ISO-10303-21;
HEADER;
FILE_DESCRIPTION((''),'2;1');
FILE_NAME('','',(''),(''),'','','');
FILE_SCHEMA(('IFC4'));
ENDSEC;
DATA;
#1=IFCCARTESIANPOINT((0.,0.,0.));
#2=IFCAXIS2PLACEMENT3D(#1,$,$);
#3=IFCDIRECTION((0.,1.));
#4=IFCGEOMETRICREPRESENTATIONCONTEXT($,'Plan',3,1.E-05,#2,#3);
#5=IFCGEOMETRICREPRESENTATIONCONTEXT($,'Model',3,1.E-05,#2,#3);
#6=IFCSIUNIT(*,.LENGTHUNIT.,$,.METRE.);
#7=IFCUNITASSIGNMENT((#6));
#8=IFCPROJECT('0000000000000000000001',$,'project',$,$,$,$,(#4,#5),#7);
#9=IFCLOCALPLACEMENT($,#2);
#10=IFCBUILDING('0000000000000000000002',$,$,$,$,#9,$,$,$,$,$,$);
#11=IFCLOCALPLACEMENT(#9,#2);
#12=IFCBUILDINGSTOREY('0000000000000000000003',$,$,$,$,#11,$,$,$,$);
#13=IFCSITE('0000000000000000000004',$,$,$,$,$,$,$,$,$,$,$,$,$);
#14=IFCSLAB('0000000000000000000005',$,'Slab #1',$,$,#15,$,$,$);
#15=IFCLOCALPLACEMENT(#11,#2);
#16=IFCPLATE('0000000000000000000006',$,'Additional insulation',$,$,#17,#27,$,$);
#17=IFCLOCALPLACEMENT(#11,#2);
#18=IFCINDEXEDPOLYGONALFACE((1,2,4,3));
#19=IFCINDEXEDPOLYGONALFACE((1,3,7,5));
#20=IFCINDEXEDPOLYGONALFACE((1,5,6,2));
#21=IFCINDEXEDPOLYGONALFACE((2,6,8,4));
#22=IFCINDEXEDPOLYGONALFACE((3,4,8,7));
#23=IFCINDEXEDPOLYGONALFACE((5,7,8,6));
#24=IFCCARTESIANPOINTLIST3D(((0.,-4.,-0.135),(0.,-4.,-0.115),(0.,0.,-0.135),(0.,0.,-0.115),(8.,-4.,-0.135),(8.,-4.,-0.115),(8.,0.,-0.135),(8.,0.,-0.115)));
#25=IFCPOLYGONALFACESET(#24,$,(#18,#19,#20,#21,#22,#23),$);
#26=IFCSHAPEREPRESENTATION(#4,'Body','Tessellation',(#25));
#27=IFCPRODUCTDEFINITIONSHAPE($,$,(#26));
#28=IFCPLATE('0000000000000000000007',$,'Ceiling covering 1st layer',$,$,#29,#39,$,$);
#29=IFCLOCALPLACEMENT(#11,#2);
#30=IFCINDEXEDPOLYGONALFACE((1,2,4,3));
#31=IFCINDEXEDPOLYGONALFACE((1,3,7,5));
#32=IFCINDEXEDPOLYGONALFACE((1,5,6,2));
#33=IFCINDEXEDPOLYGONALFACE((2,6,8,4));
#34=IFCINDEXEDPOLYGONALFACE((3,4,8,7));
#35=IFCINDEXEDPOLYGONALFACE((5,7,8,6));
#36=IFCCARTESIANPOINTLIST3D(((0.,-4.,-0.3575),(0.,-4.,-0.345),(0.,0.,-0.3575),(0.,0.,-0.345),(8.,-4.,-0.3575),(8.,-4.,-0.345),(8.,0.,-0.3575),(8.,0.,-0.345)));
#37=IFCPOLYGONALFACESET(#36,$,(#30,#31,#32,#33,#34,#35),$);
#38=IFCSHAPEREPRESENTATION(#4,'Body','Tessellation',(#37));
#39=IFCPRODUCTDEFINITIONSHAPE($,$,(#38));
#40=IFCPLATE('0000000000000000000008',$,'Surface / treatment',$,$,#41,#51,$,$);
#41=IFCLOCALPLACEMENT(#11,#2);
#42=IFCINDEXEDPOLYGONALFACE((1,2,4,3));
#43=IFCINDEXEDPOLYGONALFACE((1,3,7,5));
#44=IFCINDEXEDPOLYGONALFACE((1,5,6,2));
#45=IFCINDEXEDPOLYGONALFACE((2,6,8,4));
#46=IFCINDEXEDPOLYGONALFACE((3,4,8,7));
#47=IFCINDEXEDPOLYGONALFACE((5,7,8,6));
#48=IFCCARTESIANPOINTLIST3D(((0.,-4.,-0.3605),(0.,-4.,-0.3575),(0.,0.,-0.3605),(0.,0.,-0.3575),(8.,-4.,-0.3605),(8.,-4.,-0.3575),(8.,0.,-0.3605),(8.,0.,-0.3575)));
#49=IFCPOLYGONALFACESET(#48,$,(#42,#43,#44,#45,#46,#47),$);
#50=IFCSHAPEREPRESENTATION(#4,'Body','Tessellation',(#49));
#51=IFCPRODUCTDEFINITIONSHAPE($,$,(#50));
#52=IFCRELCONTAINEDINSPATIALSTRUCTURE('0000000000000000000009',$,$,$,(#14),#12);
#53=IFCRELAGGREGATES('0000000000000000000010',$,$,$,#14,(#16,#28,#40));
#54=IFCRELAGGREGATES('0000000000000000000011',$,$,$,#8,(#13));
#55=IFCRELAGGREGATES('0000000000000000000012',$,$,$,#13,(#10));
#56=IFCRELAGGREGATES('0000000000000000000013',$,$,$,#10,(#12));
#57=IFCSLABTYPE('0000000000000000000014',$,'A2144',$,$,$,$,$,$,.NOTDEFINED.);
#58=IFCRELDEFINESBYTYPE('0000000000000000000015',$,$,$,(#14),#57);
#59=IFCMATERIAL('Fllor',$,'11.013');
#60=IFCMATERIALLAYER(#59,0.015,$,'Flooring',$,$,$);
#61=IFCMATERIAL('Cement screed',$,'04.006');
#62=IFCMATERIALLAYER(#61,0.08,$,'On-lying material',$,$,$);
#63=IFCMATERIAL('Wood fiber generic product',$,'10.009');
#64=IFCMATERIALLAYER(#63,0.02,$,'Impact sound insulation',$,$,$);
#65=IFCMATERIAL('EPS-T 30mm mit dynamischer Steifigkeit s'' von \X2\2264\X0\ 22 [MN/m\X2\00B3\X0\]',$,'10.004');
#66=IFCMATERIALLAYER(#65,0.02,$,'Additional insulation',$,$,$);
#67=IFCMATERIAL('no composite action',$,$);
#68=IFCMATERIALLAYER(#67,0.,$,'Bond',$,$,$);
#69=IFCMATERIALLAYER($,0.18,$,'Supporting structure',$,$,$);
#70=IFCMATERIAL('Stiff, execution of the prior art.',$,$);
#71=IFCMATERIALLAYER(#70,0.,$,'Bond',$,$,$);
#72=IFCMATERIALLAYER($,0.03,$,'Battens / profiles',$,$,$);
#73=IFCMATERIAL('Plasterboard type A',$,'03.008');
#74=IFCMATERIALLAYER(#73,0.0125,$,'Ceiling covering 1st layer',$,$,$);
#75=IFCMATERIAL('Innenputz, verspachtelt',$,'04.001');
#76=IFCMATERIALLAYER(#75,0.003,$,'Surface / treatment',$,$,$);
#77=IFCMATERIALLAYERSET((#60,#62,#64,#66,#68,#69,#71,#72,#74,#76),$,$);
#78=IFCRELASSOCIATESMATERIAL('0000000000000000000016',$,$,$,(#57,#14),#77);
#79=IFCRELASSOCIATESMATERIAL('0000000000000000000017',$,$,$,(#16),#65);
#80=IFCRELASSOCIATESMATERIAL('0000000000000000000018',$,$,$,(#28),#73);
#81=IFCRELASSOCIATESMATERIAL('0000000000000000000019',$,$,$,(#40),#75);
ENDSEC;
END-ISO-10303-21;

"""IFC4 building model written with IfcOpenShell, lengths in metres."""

from ifc_helpers import new_model, si_unit, direction, frame, frame_2d, origin, place, context, project, spatial, rectangle, extrude, material, layer, layer_set, type_object, element, aggregate, save


model = new_model("IFC4")

# Units and contexts
plan_context = context("Plan", 3, precision=1e-05, world=origin(), true_north=direction((0.0, 1.0)))
model_context = context("Model", 3, precision=1e-05, world=origin(), true_north=direction((0.0, 1.0)))
ifc_project = project(units=[si_unit("LENGTHUNIT", "METRE")], contexts=[plan_context, model_context])

# Site, building, storey
site = spatial("IfcSite", under=ifc_project)
building_placement = place(None, origin())
building = spatial("IfcBuilding", under=site, at=building_placement)
storey_placement = place(building_placement, origin())
storey = spatial("IfcBuildingStorey", under=building, at=storey_placement)

# Slab, plates
ifc_material_1 = material(Name="Fllor", Category="11.013")
ifc_layer_1 = layer(ifc_material_1, 0.015, Name="Flooring")
ifc_material_2 = material(Name="Cement screed", Category="04.006")
ifc_layer_2 = layer(ifc_material_2, 0.08, Name="On-lying material")
ifc_material_3 = material(Name="Wood fiber generic product", Category="10.009")
ifc_layer_3 = layer(ifc_material_3, 0.02, Name="Impact sound insulation")
ifc_material_4 = material(Name="EPS-T 30mm mit dynamischer Steifigkeit s' von ≤ 22 [MN/m³]", Category="10.004")
ifc_layer_4 = layer(ifc_material_4, 0.02, Name="Additional insulation")
ifc_material_5 = material(Name="no composite action")
ifc_layer_5 = layer(ifc_material_5, 0.0, Name="Bond")
ifc_layer_6 = layer(None, 0.18, Name="Supporting structure")
ifc_material_6 = material(Name="Stiff, execution of the prior art.")
ifc_layer_7 = layer(ifc_material_6, 0.0, Name="Bond")
ifc_layer_8 = layer(None, 0.03, Name="Battens / profiles")
ifc_material_7 = material(Name="Plasterboard type A", Category="03.008")
ifc_layer_9 = layer(ifc_material_7, 0.0125, Name="Ceiling covering 1st layer")
ifc_material_8 = material(Name="Innenputz, verspachtelt", Category="04.001")
ifc_layer_10 = layer(ifc_material_8, 0.003, Name="Surface / treatment")
ifc_layer_set = layer_set([ifc_layer_1, ifc_layer_2, ifc_layer_3, ifc_layer_4, ifc_layer_5, ifc_layer_6, ifc_layer_7, ifc_layer_8, ifc_layer_9, ifc_layer_10])
slab_type = type_object("IfcSlabType", Name="A2144", PredefinedType="NOTDEFINED", material=ifc_layer_set)
slab_placement = place(None, frame((0.0, 0.0, 0.0), z_axis=(0.0, 0.0, -1.0), x_axis=(1.0, 0.0, 0.0)))
slab = element("IfcSlab", 1, at=slab_placement, inside=storey, type_object=slab_type, material=ifc_layer_set, Name="Slab #1")
plate_1_placement = place(slab_placement, origin())
plate_1 = element("IfcPlate", 2, at=plate_1_placement, material=ifc_material_4, Name="Additional insulation", context=plan_context, shape_type="SweptSolid", body=[
    extrude(rectangle(XDim=8.0, YDim=4.0, at=frame_2d((4.0, 2.0), x_axis=(1.0, 0.0))), frame((0.0, 0.0, 0.115), z_axis=(0.0, 0.0, 1.0), x_axis=(1.0, 0.0, 0.0)), (0.0, 0.0, 1.0), 0.02),
])
plate_2_placement = place(slab_placement, origin())
plate_2 = element("IfcPlate", 3, at=plate_2_placement, material=ifc_material_7, Name="Ceiling covering 1st layer", context=plan_context, shape_type="SweptSolid", body=[
    extrude(rectangle(XDim=8.0, YDim=4.0, at=frame_2d((4.0, 2.0), x_axis=(1.0, 0.0))), frame((0.0, 0.0, 0.345), z_axis=(0.0, 0.0, 1.0), x_axis=(1.0, 0.0, 0.0)), (0.0, 0.0, 1.0), 0.0125),
])
plate_3_placement = place(slab_placement, origin())
plate_3 = element("IfcPlate", 4, at=plate_3_placement, material=ifc_material_8, Name="Surface / treatment", context=plan_context, shape_type="SweptSolid", body=[
    extrude(rectangle(XDim=8.0, YDim=4.0, at=frame_2d((4.0, 2.0), x_axis=(1.0, 0.0))), frame((0.0, 0.0, 0.3575), z_axis=(0.0, 0.0, 1.0), x_axis=(1.0, 0.0, 0.0)), (0.0, 0.0, 1.0), 0.003),
])
aggregate(slab, [plate_1, plate_2, plate_3])

save(model, "model.ifc")
